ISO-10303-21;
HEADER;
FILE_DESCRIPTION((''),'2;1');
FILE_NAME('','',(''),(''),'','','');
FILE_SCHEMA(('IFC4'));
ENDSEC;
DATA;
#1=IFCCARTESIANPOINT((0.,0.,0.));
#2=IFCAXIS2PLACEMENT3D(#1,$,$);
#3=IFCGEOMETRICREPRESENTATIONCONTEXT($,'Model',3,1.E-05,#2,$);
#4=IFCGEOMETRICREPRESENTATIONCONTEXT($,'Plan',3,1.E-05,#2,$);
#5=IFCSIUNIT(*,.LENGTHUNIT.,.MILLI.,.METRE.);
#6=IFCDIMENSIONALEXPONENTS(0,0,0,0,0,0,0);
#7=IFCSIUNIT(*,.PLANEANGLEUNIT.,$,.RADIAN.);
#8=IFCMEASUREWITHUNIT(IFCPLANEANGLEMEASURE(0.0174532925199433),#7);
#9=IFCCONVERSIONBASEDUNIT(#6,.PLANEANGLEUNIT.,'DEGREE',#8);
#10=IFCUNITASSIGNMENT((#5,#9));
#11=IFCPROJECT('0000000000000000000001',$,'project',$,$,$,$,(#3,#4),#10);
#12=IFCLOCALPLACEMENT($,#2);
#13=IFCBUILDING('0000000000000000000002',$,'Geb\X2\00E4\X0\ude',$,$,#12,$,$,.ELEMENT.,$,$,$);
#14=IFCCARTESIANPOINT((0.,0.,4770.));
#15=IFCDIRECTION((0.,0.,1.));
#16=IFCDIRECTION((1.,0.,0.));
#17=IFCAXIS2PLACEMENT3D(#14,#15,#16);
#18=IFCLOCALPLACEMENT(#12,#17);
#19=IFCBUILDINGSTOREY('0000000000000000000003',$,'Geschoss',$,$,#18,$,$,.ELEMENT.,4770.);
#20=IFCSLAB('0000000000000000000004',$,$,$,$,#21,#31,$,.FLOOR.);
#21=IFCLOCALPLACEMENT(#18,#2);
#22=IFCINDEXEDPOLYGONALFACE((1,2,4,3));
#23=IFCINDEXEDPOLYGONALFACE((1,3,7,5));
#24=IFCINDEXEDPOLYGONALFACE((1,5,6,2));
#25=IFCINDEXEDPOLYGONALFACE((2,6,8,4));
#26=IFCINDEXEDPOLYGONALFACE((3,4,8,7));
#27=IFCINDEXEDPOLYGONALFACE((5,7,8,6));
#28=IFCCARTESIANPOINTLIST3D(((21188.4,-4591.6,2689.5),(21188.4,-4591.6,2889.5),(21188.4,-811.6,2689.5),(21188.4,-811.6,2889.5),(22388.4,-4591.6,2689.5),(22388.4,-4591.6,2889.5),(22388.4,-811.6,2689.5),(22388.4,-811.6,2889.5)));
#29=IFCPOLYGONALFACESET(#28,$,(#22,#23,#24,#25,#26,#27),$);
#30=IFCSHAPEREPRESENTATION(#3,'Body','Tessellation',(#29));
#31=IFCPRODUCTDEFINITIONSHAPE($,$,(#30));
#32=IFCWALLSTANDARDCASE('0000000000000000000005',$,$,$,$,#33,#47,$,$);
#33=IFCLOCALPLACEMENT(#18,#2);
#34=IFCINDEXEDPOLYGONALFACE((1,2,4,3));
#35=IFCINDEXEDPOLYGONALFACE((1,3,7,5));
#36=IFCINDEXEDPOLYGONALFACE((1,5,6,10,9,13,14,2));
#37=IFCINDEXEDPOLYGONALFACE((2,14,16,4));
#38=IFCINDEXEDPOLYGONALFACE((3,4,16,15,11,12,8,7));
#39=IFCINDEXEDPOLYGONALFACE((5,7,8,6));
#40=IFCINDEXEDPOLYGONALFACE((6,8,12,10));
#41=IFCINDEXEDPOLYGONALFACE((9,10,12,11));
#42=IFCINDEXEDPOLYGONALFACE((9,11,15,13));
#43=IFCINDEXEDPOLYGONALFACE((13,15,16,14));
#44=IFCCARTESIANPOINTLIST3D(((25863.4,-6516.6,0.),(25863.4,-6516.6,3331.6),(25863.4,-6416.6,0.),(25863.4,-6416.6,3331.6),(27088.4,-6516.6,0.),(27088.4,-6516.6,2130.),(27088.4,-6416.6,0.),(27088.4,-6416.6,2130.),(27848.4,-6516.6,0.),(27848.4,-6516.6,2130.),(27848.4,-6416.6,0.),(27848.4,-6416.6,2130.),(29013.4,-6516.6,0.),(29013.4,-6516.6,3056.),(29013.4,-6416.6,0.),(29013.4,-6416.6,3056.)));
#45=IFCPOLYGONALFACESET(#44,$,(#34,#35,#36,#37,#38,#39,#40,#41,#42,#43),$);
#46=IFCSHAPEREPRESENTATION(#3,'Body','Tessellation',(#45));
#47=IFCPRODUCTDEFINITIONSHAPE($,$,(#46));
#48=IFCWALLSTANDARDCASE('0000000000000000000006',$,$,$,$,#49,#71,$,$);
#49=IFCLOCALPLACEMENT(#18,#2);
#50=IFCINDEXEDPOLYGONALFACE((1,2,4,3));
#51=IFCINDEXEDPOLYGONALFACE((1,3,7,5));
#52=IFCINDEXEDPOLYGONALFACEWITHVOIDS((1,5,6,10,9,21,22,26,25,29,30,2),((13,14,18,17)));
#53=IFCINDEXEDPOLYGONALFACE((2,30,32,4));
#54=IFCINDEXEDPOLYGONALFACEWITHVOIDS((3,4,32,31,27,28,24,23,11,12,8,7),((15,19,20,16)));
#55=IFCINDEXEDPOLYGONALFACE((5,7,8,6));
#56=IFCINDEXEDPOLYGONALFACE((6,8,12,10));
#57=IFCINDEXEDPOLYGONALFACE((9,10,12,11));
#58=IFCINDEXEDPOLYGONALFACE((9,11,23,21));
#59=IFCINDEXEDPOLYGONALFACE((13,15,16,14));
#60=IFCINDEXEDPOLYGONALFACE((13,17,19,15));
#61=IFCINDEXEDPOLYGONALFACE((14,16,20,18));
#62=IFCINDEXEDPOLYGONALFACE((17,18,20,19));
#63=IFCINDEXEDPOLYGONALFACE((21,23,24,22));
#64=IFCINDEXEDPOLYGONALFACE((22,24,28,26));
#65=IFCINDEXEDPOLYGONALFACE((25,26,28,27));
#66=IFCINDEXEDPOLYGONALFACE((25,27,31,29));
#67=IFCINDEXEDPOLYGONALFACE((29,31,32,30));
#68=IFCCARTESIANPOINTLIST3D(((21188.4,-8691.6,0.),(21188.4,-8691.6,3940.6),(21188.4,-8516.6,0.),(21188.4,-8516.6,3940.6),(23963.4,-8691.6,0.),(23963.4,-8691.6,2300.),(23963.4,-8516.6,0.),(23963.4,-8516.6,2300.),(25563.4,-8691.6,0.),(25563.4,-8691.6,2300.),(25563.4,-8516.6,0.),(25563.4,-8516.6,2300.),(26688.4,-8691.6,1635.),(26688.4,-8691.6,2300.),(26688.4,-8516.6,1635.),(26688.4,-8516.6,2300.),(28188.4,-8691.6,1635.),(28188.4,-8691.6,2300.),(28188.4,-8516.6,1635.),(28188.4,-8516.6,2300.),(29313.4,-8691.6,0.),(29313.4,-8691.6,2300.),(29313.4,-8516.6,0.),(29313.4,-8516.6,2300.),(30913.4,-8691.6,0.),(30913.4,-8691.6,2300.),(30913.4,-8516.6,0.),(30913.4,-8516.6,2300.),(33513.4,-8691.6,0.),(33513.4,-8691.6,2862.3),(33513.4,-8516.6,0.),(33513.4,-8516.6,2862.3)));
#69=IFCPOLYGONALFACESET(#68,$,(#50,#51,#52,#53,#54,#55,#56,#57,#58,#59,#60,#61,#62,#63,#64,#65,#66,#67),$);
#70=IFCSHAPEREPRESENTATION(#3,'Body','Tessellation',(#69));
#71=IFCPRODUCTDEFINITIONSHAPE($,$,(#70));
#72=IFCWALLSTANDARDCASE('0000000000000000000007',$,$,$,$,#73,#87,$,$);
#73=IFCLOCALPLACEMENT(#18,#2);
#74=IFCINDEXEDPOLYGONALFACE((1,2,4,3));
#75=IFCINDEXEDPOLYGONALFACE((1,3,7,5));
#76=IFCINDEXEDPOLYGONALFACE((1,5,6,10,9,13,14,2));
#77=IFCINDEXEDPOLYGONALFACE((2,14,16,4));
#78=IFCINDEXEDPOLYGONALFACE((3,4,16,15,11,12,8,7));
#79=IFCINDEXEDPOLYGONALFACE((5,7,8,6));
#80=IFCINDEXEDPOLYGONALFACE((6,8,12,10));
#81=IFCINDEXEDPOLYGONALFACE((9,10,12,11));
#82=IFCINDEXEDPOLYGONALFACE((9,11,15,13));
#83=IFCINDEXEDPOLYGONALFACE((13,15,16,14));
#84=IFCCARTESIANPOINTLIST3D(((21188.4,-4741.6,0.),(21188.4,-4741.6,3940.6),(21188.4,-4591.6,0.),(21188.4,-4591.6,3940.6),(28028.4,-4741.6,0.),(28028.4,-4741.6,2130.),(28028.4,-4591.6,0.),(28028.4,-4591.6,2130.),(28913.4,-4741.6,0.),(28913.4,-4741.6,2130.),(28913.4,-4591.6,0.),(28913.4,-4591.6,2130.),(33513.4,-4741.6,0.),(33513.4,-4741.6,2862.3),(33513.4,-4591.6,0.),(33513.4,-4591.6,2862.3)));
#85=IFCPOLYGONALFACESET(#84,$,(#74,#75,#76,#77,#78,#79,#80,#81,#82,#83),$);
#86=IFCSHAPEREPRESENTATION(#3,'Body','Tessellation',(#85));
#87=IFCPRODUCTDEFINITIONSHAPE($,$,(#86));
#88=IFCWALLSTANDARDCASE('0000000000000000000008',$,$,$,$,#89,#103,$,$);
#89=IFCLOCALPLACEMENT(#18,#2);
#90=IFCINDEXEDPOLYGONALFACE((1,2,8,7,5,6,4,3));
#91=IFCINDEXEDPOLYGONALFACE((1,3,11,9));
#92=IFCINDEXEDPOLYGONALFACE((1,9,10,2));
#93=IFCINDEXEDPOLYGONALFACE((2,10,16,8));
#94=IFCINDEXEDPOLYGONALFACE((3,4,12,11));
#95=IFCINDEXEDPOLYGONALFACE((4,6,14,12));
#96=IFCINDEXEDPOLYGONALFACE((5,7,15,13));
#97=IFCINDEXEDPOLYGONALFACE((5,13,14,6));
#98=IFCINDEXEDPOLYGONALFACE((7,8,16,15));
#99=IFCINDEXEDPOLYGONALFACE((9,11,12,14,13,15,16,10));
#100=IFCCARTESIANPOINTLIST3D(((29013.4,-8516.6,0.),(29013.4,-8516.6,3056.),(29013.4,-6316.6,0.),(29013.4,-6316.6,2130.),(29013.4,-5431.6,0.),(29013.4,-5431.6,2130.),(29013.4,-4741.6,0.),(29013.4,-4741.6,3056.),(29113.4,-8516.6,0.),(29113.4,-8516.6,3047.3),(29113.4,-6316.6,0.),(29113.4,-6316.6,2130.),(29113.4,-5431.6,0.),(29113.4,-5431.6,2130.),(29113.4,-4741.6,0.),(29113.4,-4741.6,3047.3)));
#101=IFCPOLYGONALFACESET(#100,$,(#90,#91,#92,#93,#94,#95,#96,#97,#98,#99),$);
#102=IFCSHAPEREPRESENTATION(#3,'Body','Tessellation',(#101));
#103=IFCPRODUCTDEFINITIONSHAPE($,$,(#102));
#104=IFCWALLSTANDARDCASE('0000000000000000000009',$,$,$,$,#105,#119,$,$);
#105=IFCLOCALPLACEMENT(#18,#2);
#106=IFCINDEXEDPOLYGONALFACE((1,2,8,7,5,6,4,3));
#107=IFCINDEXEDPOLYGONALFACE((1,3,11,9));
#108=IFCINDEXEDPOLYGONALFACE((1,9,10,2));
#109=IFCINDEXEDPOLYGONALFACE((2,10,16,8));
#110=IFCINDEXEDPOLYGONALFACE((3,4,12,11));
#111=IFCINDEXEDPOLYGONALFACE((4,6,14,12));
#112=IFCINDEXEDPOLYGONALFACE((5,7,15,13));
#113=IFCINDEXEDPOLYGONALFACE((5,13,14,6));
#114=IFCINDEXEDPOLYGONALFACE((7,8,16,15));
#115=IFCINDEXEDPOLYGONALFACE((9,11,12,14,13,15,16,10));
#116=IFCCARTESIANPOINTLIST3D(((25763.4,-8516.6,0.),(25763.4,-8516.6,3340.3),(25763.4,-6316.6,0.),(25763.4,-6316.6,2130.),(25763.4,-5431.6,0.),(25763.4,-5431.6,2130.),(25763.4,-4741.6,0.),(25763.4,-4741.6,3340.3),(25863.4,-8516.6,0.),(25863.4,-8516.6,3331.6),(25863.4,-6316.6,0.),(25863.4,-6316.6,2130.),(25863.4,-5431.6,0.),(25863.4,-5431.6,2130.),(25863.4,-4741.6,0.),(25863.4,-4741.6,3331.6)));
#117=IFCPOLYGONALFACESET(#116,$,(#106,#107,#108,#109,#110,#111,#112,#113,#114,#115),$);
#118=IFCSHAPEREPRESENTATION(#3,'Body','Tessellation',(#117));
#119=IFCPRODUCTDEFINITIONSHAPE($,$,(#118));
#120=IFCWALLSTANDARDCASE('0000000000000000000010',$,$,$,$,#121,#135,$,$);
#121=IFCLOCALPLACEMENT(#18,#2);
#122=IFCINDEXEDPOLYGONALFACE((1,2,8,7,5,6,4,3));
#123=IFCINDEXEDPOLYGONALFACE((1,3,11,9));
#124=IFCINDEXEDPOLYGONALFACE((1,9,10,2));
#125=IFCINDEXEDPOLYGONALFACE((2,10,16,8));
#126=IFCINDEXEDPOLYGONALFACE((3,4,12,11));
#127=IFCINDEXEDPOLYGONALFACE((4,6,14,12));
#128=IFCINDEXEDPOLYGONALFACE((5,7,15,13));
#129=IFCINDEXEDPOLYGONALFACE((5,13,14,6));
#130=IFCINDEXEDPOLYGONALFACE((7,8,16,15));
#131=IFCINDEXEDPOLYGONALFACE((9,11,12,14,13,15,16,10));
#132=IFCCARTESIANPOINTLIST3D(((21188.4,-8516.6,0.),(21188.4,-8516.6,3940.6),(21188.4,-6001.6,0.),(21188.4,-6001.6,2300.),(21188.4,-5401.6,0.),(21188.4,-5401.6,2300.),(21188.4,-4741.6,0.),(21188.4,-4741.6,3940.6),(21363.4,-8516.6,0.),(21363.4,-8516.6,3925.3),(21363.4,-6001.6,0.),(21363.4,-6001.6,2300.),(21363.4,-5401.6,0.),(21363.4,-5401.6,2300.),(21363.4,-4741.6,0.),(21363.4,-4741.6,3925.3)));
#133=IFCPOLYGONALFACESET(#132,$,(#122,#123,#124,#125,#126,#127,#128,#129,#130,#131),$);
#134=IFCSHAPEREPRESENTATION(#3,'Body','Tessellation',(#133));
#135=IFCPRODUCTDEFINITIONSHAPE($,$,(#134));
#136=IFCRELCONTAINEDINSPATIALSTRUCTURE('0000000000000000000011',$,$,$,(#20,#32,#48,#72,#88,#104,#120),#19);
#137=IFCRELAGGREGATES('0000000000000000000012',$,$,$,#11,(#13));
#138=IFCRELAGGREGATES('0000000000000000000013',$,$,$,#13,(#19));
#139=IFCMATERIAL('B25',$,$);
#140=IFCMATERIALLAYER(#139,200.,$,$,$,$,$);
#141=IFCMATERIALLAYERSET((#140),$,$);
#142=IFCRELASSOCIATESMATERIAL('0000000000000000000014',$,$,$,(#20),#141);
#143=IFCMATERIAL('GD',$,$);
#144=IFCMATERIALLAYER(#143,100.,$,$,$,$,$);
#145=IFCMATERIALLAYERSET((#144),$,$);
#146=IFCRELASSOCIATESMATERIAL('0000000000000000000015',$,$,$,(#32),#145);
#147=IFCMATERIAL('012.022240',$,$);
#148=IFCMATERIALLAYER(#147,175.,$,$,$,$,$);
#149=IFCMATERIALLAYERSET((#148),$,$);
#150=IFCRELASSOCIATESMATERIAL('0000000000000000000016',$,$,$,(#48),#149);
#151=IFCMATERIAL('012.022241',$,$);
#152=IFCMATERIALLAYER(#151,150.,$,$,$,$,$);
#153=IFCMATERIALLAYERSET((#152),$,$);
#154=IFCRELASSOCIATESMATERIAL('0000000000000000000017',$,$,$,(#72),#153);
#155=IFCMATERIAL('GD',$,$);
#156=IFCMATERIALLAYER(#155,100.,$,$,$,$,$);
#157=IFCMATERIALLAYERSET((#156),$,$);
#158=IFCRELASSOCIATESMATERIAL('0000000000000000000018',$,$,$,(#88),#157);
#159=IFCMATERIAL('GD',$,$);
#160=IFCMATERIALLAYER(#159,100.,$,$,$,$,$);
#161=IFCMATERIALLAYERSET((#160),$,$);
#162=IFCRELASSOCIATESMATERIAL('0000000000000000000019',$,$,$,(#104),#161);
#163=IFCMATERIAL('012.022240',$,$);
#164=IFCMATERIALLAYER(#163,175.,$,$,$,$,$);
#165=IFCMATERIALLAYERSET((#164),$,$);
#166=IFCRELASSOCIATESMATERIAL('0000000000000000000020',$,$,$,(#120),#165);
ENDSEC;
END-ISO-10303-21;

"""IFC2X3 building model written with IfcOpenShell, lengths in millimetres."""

from ifc_helpers import new_model, entity, si_unit, converted_unit, frame, frame_2d, origin, origin_with_axes, place, context, project, spatial, rectangle, extrude, clip, halfspace, material, layer, layer_set, layer_usage, element, save


model = new_model("IFC2X3")

# Units and contexts
model_context = context("Model", 3, precision=1e-05, world=origin())
plan_context = context("Plan", 3, precision=1e-05, world=origin())
ifc_project = project(units=[si_unit("LENGTHUNIT", "METRE", prefix="MILLI"), converted_unit("PLANEANGLEUNIT", "DEGREE", entity("IfcPlaneAngleMeasure", 0.0174532925199433), si_unit("PLANEANGLEUNIT", "RADIAN"), dimensions=[0, 0, 0, 0, 0, 0, 0])], contexts=[model_context, plan_context])

# Building, storey
building_placement = place(None, origin())
building = spatial("IfcBuilding", under=ifc_project, at=building_placement, Name="Gebäude", CompositionType="ELEMENT")
storey_placement = place(building_placement, frame((0.0, 0.0, 4770.0), z_axis=(0.0, 0.0, 1.0), x_axis=(1.0, 0.0, 0.0)))
storey = spatial("IfcBuildingStorey", under=building, at=storey_placement, Name="Geschoss", CompositionType="ELEMENT", Elevation=4770.0)

# Slab
ifc_material_1 = material(Name="B25")
ifc_layer_1 = layer(ifc_material_1, 200.0)
ifc_layer_set_1 = layer_set([ifc_layer_1])
ifc_layer_usage_1 = layer_usage(ifc_layer_set_1, "AXIS3", "POSITIVE", 0.0)
slab_placement = place(storey_placement, frame((22388.4, -4591.6, 2689.5), z_axis=(0.0, 0.0, 1.0), x_axis=(1.0, 0.0, 0.0)))
element("IfcSlab", 1, at=slab_placement, inside=storey, material=ifc_layer_usage_1, PredefinedType="FLOOR", context=model_context, shape_type="SweptSolid", body=[
    extrude(rectangle(XDim=3780.0, YDim=1200.0, at=frame_2d((-600.0, 1890.0), x_axis=(0.0, 1.0))), origin_with_axes(), (0.0, 0.0, 1.0), 200.0),
])

# Wall, opening
ifc_material_2 = material(Name="GD")
ifc_layer_2 = layer(ifc_material_2, 100.0)
ifc_layer_set_2 = layer_set([ifc_layer_2])
ifc_layer_usage_2 = layer_usage(ifc_layer_set_2, "AXIS2", "POSITIVE", 0.0)
wall_1_placement = place(storey_placement, frame((25863.4, -6516.6, 0.0), z_axis=(0.0, 0.0, 1.0), x_axis=(1.0, 0.0, 0.0)))
wall_1 = element("IfcWallStandardCase", 2, at=wall_1_placement, inside=storey, material=ifc_layer_usage_2, context=model_context, shape_type="Clipping", body=[
    clip(extrude(rectangle(XDim=3150.0, YDim=100.0, at=frame_2d((1575.0, 50.0), x_axis=(1.0, 0.0))), origin_with_axes(), (0.0, 0.0, 1.0), 3331.6), halfspace(frame((0.0, 0.0, 3331.6), z_axis=(-0.087156, 0.0, -0.996195), x_axis=(1.0, 0.0, 0.0)), True)),
])
opening_1_placement = place(wall_1_placement, frame((1225.0, 0.0, 0.0), z_axis=(0.0, 1.0, 0.0), x_axis=(0.0, 0.0, 1.0)))
element("IfcOpeningElement", 3, at=opening_1_placement, cuts=wall_1, ObjectType="Opening", context=model_context, shape_type="SweptSolid", body=[
    extrude(rectangle(XDim=2130.0, YDim=760.0, at=frame_2d((1065.0, 380.0), x_axis=(1.0, 0.0))), origin_with_axes(), (0.0, 0.0, 1.0), 100.0),
])

# Wall, openings
ifc_material_3 = material(Name="012.022240")
ifc_layer_3 = layer(ifc_material_3, 175.0)
ifc_layer_set_3 = layer_set([ifc_layer_3])
ifc_layer_usage_3 = layer_usage(ifc_layer_set_3, "AXIS2", "POSITIVE", 0.0)
wall_2_placement = place(storey_placement, frame((21188.4, -8691.6, 0.0), z_axis=(0.0, 0.0, 1.0), x_axis=(1.0, 0.0, 0.0)))
wall_2 = element("IfcWallStandardCase", 4, at=wall_2_placement, inside=storey, material=ifc_layer_usage_3, context=model_context, shape_type="Clipping", body=[
    clip(extrude(rectangle(XDim=12325.0, YDim=175.0, at=frame_2d((6162.5, 87.5), x_axis=(1.0, 0.0))), origin_with_axes(), (0.0, 0.0, 1.0), 3940.6), halfspace(frame((12325.0, 175.0, 2862.3), z_axis=(-0.087156, 0.0, -0.996195), x_axis=(1.0, 0.0, 0.0)), True)),
])
opening_2_placement = place(wall_2_placement, frame((8125.0, 0.0, 0.0), z_axis=(0.0, 1.0, 0.0), x_axis=(0.0, 0.0, 1.0)))
element("IfcOpeningElement", 5, at=opening_2_placement, cuts=wall_2, ObjectType="Opening", context=model_context, shape_type="SweptSolid", body=[
    extrude(rectangle(XDim=2300.0, YDim=1600.0, at=frame_2d((1150.0, 800.0), x_axis=(1.0, 0.0))), origin_with_axes(), (0.0, 0.0, 1.0), 175.0),
])
opening_3_placement = place(wall_2_placement, frame((5500.0, 0.0, 1635.0), z_axis=(0.0, 1.0, 0.0), x_axis=(0.0, 0.0, 1.0)))
element("IfcOpeningElement", 6, at=opening_3_placement, cuts=wall_2, ObjectType="Opening", context=model_context, shape_type="SweptSolid", body=[
    extrude(rectangle(XDim=665.0, YDim=1500.0, at=frame_2d((332.5, 750.0), x_axis=(1.0, 0.0))), origin_with_axes(), (0.0, 0.0, 1.0), 175.0),
])
opening_4_placement = place(wall_2_placement, frame((2775.0, 0.0, 0.0), z_axis=(0.0, 1.0, 0.0), x_axis=(0.0, 0.0, 1.0)))
element("IfcOpeningElement", 7, at=opening_4_placement, cuts=wall_2, ObjectType="Opening", context=model_context, shape_type="SweptSolid", body=[
    extrude(rectangle(XDim=2300.0, YDim=1600.0, at=frame_2d((1150.0, 800.0), x_axis=(1.0, 0.0))), origin_with_axes(), (0.0, 0.0, 1.0), 175.0),
])

# Walls, openings
ifc_material_4 = material(Name="012.022241")
ifc_layer_4 = layer(ifc_material_4, 150.0)
ifc_layer_set_4 = layer_set([ifc_layer_4])
ifc_layer_usage_4 = layer_usage(ifc_layer_set_4, "AXIS2", "POSITIVE", 0.0)
wall_3_placement = place(storey_placement, frame((21188.4, -4741.6, 0.0), z_axis=(0.0, 0.0, 1.0), x_axis=(1.0, 0.0, 0.0)))
wall_3 = element("IfcWallStandardCase", 8, at=wall_3_placement, inside=storey, material=ifc_layer_usage_4, context=model_context, shape_type="Clipping", body=[
    clip(extrude(rectangle(XDim=12325.0, YDim=150.0, at=frame_2d((6162.5, 75.0), x_axis=(1.0, 0.0))), origin_with_axes(), (0.0, 0.0, 1.0), 3940.6), halfspace(frame((12325.0, 150.0, 2862.3), z_axis=(-0.087156, 0.0, -0.996195), x_axis=(1.0, 0.0, 0.0)), True)),
])
opening_5_placement = place(wall_3_placement, frame((6840.0, 0.0, 0.0), z_axis=(0.0, 1.0, 0.0), x_axis=(0.0, 0.0, 1.0)))
element("IfcOpeningElement", 9, at=opening_5_placement, cuts=wall_3, ObjectType="Opening", context=model_context, shape_type="SweptSolid", body=[
    extrude(rectangle(XDim=2130.0, YDim=885.0, at=frame_2d((1065.0, 442.5), x_axis=(1.0, 0.0))), origin_with_axes(), (0.0, 0.0, 1.0), 150.0),
])
ifc_material_5 = material(Name="GD")
ifc_layer_5 = layer(ifc_material_5, 100.0)
ifc_layer_set_5 = layer_set([ifc_layer_5])
ifc_layer_usage_5 = layer_usage(ifc_layer_set_5, "AXIS2", "POSITIVE", 0.0)
wall_4_placement = place(storey_placement, frame((29113.4, -8516.6, 0.0), z_axis=(0.0, 0.0, 1.0), x_axis=(0.0, 1.0, 0.0)))
wall_4 = element("IfcWallStandardCase", 10, at=wall_4_placement, inside=storey, material=ifc_layer_usage_5, context=model_context, shape_type="Clipping", body=[
    clip(extrude(rectangle(XDim=3775.0, YDim=100.0, at=frame_2d((1887.5, 50.0), x_axis=(1.0, 0.0))), origin_with_axes(), (0.0, 0.0, 1.0), 3056.0), halfspace(frame((0.0, 0.0, 3047.3), z_axis=(0.0, 0.087156, -0.996195), x_axis=(1.0, 0.0, 0.0)), True)),
])
opening_6_placement = place(wall_4_placement, frame((2200.0, 0.0, 0.0), z_axis=(0.0, 1.0, 0.0), x_axis=(0.0, 0.0, 1.0)))
element("IfcOpeningElement", 11, at=opening_6_placement, cuts=wall_4, ObjectType="Opening", context=model_context, shape_type="SweptSolid", body=[
    extrude(rectangle(XDim=2130.0, YDim=885.0, at=frame_2d((1065.0, 442.5), x_axis=(1.0, 0.0))), origin_with_axes(), (0.0, 0.0, 1.0), 100.0),
])
ifc_material_6 = material(Name="GD")
ifc_layer_6 = layer(ifc_material_6, 100.0)
ifc_layer_set_6 = layer_set([ifc_layer_6])
ifc_layer_usage_6 = layer_usage(ifc_layer_set_6, "AXIS2", "POSITIVE", 0.0)
wall_5_placement = place(storey_placement, frame((25763.4, -4741.6, 0.0), z_axis=(0.0, 0.0, 1.0), x_axis=(0.0, -1.0, 0.0)))
wall_5 = element("IfcWallStandardCase", 12, at=wall_5_placement, inside=storey, material=ifc_layer_usage_6, context=model_context, shape_type="Clipping", body=[
    clip(extrude(rectangle(XDim=3775.0, YDim=100.0, at=frame_2d((1887.5, 50.0), x_axis=(1.0, 0.0))), origin_with_axes(), (0.0, 0.0, 1.0), 3340.3), halfspace(frame((0.0, 0.0, 3340.3), z_axis=(0.0, -0.087156, -0.996195), x_axis=(1.0, 0.0, 0.0)), True)),
])
opening_7_placement = place(wall_5_placement, frame((690.0, 0.0, 0.0), z_axis=(0.0, 1.0, 0.0), x_axis=(0.0, 0.0, 1.0)))
element("IfcOpeningElement", 13, at=opening_7_placement, cuts=wall_5, ObjectType="Opening", context=model_context, shape_type="SweptSolid", body=[
    extrude(rectangle(XDim=2130.0, YDim=885.0, at=frame_2d((1065.0, 442.5), x_axis=(1.0, 0.0))), origin_with_axes(), (0.0, 0.0, 1.0), 100.0),
])
ifc_material_7 = material(Name="012.022240")
ifc_layer_7 = layer(ifc_material_7, 175.0)
ifc_layer_set_7 = layer_set([ifc_layer_7])
ifc_layer_usage_7 = layer_usage(ifc_layer_set_7, "AXIS2", "POSITIVE", 0.0)
wall_6_placement = place(storey_placement, frame((21188.4, -4741.6, 0.0), z_axis=(0.0, 0.0, 1.0), x_axis=(0.0, -1.0, 0.0)))
wall_6 = element("IfcWallStandardCase", 14, at=wall_6_placement, inside=storey, material=ifc_layer_usage_7, context=model_context, shape_type="Clipping", body=[
    clip(extrude(rectangle(XDim=3775.0, YDim=175.0, at=frame_2d((1887.5, 87.5), x_axis=(1.0, 0.0))), origin_with_axes(), (0.0, 0.0, 1.0), 3940.6), halfspace(frame((0.0, 175.0, 3925.3), z_axis=(0.0, -0.087156, -0.996195), x_axis=(1.0, 0.0, 0.0)), True)),
])
opening_8_placement = place(wall_6_placement, frame((660.0, 0.0, 0.0), z_axis=(0.0, 1.0, 0.0), x_axis=(0.0, 0.0, 1.0)))
element("IfcOpeningElement", 15, at=opening_8_placement, cuts=wall_6, ObjectType="Opening", context=model_context, shape_type="SweptSolid", body=[
    extrude(rectangle(XDim=2300.0, YDim=600.0, at=frame_2d((1150.0, 300.0), x_axis=(1.0, 0.0))), origin_with_axes(), (0.0, 0.0, 1.0), 175.0),
])

save(model, "model.ifc")
